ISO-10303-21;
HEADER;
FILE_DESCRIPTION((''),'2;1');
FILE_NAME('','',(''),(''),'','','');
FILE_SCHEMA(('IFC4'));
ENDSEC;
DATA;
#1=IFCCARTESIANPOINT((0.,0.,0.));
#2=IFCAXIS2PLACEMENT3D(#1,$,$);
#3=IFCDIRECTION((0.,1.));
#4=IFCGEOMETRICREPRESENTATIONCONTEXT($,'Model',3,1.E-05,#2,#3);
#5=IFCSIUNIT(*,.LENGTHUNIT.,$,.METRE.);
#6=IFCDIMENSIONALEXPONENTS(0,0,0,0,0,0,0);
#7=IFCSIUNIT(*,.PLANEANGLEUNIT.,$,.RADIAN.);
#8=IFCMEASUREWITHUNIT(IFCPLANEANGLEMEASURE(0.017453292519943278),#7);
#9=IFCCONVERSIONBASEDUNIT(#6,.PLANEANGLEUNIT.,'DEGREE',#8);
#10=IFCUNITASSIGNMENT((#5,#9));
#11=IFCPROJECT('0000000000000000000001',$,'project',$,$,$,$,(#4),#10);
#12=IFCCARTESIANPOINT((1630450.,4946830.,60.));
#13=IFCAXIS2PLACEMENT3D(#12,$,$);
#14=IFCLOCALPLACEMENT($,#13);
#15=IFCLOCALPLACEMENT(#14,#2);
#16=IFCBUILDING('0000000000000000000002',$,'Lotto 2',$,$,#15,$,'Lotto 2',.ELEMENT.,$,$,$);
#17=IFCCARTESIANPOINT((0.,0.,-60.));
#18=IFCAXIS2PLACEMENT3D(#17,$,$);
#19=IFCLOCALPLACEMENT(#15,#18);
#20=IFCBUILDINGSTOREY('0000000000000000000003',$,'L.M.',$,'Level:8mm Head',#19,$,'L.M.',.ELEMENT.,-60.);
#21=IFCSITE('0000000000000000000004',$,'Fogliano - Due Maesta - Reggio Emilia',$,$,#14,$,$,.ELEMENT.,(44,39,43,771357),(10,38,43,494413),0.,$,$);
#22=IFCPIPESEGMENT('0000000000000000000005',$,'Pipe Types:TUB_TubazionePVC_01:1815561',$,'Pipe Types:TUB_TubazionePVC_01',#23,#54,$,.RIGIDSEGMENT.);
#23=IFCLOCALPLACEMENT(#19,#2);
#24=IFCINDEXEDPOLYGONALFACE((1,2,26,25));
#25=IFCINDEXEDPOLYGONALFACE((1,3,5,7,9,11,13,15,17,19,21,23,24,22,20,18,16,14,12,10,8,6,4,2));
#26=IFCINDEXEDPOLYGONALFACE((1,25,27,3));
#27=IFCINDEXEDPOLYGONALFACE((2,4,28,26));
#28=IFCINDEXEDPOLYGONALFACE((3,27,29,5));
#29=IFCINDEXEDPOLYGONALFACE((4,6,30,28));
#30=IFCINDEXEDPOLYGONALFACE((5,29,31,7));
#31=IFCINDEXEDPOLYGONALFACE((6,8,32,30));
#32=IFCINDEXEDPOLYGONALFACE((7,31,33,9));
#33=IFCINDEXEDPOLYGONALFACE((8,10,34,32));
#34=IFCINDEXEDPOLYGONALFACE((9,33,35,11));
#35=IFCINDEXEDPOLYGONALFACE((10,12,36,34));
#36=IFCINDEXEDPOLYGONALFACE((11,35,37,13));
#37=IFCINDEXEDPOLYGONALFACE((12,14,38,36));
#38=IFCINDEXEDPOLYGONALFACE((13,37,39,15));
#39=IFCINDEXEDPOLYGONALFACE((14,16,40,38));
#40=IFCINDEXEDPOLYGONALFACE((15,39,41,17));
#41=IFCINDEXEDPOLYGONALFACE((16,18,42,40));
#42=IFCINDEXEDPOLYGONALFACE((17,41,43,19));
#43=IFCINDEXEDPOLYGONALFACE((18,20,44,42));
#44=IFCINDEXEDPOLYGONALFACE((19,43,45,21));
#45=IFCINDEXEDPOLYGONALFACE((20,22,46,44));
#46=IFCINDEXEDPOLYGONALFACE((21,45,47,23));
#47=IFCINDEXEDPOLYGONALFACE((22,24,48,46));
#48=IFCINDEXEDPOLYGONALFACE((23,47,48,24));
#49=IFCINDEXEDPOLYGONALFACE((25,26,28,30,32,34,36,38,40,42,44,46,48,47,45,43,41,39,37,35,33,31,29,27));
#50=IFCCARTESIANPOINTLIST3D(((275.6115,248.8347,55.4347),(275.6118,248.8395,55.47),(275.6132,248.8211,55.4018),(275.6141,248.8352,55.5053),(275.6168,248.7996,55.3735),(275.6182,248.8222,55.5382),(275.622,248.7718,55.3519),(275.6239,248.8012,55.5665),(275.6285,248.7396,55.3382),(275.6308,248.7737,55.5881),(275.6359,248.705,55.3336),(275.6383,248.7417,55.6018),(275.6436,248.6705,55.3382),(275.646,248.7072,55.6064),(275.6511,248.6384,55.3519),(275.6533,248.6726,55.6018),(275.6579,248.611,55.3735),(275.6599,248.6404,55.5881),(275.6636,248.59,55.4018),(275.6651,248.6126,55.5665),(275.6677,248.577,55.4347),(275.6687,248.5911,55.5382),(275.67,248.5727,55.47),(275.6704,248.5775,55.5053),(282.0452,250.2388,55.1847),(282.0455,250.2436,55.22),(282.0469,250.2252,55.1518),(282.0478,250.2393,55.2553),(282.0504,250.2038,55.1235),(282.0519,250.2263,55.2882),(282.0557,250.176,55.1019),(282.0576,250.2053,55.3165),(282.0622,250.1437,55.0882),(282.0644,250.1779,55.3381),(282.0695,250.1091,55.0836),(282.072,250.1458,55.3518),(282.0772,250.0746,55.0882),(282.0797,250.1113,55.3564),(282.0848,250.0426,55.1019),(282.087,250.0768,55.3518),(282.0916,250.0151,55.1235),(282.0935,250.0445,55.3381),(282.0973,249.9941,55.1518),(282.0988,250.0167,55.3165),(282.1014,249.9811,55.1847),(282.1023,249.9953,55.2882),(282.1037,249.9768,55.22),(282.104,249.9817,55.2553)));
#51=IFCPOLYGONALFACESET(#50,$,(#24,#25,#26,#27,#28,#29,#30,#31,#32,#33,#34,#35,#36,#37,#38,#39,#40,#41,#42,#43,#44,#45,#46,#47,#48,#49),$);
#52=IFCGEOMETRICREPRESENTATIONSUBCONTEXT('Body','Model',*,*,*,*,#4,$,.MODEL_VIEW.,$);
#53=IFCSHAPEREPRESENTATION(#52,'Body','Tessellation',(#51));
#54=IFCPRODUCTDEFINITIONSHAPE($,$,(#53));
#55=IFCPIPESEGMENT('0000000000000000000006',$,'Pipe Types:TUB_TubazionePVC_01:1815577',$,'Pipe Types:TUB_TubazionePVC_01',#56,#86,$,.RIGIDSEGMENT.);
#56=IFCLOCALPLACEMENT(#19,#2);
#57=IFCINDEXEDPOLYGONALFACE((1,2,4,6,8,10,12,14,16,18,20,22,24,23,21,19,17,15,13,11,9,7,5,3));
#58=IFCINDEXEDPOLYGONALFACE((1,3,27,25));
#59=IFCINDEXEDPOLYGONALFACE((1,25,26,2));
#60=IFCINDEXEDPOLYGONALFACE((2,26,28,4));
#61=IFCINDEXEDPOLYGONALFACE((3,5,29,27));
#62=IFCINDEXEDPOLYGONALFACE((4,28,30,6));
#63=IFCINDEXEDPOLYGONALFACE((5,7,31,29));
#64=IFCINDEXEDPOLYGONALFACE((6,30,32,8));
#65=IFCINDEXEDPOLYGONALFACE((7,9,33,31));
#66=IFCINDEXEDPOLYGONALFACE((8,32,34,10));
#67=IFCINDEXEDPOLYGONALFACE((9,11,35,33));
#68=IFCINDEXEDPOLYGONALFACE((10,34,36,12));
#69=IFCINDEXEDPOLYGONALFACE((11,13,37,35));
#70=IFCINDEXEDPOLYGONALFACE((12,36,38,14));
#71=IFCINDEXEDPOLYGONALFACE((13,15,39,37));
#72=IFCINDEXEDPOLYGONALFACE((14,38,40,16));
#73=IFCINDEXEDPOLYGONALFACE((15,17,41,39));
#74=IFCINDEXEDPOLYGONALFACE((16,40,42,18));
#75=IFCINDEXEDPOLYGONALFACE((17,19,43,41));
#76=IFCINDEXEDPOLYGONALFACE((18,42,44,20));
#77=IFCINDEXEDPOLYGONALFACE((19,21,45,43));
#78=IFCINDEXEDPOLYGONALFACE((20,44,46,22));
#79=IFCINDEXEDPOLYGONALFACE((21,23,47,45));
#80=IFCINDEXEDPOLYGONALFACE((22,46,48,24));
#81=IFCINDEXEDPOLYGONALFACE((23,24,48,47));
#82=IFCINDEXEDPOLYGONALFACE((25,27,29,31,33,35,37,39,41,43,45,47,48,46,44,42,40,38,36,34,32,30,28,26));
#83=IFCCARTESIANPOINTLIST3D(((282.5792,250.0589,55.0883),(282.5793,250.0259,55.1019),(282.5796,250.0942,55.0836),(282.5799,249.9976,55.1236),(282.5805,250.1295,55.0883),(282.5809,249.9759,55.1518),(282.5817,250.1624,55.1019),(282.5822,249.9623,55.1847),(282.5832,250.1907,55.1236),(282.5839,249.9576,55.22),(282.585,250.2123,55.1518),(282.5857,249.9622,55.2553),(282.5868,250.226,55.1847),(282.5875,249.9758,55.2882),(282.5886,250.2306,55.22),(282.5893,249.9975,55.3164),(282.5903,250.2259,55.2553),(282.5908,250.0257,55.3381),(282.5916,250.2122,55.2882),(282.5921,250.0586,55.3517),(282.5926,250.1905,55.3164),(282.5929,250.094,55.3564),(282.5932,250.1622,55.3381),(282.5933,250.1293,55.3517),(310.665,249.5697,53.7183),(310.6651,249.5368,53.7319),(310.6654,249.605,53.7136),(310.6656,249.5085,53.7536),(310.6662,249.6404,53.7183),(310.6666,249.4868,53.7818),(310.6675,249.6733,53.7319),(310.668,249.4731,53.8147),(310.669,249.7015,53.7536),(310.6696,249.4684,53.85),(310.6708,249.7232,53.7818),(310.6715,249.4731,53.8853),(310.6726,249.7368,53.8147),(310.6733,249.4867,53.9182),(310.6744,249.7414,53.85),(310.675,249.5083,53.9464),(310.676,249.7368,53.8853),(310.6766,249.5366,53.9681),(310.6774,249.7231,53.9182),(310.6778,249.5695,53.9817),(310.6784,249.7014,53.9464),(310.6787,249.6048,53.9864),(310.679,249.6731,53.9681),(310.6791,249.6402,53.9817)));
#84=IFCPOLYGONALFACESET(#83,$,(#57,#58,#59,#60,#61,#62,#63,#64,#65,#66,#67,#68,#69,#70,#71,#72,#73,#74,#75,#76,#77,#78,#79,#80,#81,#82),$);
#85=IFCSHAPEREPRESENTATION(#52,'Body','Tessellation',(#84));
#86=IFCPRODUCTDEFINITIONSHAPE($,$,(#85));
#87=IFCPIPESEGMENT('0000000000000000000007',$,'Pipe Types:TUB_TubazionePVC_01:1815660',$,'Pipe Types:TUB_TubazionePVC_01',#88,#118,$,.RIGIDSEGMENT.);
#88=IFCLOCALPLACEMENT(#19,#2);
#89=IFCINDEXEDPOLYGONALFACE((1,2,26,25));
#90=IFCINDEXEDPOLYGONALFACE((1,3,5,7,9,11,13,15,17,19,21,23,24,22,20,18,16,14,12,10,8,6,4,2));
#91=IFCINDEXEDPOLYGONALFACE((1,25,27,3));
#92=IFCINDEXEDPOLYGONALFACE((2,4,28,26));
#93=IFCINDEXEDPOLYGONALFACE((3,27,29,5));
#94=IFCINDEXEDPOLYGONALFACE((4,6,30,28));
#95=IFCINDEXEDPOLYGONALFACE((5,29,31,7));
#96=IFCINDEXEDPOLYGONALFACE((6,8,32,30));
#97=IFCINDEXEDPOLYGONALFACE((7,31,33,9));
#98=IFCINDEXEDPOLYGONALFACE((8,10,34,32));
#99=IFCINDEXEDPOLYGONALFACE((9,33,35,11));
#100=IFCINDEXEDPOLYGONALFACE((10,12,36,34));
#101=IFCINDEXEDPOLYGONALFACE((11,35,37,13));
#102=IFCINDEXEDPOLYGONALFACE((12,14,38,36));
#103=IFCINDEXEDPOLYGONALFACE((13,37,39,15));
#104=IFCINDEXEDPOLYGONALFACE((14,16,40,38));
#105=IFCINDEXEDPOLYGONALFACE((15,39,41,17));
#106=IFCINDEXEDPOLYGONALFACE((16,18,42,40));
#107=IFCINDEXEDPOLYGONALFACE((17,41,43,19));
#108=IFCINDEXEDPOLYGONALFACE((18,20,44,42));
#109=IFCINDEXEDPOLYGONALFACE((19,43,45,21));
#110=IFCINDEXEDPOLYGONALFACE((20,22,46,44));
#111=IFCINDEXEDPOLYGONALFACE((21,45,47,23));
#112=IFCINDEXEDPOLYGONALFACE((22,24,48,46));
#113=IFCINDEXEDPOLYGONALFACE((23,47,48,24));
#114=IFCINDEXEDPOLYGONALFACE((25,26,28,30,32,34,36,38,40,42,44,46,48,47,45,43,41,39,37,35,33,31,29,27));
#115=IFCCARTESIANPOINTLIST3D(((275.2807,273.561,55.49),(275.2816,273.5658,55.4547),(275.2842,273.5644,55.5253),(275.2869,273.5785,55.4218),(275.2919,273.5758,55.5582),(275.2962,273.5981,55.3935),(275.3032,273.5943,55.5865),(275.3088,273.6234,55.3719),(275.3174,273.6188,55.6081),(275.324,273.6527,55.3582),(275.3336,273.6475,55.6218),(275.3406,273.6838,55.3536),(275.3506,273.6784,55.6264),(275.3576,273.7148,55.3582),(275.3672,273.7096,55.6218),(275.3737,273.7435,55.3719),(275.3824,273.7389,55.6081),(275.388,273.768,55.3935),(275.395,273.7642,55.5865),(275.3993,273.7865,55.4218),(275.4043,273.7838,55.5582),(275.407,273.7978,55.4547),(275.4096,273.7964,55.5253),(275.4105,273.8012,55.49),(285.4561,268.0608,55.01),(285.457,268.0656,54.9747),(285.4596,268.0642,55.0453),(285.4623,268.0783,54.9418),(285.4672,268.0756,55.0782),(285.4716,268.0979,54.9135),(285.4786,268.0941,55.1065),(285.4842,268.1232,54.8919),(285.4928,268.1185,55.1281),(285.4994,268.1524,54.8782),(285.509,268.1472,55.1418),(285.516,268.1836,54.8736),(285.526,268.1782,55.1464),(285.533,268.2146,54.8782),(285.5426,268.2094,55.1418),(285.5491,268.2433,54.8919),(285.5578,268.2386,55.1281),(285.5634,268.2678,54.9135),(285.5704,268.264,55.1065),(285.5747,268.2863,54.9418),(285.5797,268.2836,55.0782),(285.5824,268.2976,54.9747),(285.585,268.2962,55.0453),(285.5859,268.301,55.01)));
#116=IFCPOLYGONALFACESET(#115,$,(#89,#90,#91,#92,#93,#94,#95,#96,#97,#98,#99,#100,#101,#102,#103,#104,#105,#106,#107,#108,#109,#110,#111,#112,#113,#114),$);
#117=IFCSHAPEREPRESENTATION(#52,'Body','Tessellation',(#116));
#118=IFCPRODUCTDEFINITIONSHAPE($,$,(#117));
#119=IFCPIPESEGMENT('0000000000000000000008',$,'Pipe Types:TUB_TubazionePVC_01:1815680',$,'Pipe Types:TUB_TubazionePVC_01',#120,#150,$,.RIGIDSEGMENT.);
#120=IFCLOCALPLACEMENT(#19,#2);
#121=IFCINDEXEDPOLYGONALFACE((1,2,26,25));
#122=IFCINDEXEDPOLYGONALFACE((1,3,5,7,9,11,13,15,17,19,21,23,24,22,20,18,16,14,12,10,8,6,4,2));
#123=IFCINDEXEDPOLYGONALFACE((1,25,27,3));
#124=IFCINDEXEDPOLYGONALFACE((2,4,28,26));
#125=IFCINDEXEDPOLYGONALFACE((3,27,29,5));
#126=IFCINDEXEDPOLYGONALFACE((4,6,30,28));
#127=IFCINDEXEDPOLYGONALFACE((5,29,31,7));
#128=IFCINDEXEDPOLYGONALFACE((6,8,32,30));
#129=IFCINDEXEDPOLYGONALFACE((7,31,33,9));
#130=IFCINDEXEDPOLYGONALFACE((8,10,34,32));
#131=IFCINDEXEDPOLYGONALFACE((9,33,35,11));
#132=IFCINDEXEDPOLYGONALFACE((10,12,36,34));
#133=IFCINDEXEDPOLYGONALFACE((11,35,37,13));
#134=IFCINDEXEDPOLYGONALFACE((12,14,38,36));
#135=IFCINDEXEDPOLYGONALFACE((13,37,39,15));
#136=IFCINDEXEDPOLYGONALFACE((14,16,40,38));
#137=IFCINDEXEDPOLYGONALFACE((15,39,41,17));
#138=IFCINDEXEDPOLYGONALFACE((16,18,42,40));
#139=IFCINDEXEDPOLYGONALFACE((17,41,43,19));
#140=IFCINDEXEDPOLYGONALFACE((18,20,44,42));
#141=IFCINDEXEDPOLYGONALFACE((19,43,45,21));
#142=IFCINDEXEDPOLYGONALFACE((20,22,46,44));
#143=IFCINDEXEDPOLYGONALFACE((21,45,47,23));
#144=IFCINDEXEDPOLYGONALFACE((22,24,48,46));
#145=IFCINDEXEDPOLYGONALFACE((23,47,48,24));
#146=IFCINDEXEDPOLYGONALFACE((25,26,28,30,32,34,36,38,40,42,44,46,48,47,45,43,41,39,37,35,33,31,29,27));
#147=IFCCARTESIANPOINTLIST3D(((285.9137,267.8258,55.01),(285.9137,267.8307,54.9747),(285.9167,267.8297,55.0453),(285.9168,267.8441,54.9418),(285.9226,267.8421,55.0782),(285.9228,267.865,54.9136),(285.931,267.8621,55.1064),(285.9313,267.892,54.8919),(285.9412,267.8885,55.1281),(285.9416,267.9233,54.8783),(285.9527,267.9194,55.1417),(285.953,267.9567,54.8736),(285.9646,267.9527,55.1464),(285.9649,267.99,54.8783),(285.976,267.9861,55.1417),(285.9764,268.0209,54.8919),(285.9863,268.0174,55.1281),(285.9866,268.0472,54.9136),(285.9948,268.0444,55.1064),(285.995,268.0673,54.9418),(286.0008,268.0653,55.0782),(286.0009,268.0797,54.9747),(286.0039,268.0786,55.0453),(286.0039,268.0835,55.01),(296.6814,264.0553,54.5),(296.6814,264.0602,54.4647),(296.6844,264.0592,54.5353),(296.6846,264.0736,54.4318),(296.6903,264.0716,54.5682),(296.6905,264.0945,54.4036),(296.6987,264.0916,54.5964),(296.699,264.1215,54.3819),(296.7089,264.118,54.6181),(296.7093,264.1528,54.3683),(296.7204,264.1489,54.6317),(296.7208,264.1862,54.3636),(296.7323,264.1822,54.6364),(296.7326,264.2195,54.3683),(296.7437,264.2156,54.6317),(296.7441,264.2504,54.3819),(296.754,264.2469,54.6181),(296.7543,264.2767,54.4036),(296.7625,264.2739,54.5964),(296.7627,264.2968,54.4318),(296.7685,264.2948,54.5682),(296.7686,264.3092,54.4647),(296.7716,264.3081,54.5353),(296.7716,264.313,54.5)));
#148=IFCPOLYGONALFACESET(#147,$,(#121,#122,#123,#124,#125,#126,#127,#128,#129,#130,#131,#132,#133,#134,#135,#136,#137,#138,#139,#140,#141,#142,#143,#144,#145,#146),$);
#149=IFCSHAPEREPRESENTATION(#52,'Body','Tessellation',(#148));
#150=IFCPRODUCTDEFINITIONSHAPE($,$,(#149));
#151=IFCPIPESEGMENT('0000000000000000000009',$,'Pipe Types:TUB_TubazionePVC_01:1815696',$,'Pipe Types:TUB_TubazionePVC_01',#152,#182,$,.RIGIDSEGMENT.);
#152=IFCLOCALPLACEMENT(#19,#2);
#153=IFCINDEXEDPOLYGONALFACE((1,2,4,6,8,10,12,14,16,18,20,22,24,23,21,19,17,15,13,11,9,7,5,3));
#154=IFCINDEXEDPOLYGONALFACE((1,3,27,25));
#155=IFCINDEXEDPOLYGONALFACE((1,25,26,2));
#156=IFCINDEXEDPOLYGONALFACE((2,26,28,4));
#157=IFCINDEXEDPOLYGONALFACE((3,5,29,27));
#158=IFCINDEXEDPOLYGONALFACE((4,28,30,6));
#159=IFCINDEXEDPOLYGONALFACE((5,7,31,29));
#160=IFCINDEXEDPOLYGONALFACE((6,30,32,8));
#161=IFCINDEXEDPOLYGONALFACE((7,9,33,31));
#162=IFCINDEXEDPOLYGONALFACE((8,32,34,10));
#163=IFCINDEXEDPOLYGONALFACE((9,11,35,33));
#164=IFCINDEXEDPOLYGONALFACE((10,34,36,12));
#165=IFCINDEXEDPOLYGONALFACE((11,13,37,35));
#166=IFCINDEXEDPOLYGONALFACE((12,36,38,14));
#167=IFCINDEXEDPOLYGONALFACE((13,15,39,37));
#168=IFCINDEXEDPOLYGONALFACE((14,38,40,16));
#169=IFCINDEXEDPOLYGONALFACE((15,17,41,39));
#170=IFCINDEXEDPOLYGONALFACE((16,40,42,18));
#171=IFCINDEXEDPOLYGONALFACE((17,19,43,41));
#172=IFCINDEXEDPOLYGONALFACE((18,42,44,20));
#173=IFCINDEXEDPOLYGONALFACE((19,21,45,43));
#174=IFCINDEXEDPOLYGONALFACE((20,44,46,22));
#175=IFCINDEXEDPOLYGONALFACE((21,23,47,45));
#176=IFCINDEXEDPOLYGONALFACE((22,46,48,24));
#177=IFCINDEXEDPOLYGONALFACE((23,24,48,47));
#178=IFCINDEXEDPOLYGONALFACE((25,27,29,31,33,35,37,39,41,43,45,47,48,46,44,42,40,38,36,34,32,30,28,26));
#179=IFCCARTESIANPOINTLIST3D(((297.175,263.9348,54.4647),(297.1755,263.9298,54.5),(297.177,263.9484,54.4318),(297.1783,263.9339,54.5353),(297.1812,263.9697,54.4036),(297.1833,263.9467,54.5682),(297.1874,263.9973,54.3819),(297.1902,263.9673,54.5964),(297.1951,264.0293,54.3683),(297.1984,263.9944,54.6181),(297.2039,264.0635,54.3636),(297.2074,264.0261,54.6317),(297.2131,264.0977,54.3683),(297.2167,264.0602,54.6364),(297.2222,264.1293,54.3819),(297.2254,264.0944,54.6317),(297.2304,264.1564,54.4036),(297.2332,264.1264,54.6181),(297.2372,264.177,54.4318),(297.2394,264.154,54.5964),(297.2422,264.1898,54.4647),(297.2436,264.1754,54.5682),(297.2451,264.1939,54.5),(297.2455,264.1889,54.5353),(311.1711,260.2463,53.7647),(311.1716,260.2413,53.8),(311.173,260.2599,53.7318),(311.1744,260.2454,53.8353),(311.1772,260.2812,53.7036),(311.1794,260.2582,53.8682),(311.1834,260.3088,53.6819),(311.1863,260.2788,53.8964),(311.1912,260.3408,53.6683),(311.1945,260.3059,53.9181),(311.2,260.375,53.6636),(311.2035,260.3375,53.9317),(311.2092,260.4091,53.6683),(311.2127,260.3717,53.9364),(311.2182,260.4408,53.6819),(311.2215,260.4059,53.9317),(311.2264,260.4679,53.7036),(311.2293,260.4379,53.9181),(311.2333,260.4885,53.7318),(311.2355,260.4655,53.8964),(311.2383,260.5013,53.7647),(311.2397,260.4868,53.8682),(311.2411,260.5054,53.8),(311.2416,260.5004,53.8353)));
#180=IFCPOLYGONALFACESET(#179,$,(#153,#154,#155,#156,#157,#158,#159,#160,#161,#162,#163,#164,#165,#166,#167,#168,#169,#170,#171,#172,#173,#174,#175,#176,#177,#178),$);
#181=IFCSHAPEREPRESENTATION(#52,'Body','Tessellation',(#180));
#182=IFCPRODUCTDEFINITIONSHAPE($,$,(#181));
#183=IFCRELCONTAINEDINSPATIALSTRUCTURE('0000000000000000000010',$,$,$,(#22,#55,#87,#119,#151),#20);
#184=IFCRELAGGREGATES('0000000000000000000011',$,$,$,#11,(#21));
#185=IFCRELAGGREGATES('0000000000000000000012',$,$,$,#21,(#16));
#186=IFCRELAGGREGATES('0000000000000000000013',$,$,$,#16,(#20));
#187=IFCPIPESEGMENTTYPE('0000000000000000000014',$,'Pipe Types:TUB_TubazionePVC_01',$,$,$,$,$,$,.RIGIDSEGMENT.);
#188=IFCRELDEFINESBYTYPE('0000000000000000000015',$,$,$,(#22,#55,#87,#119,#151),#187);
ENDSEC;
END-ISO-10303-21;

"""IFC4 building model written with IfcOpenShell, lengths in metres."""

from ifc_helpers import new_model, entity, si_unit, converted_unit, direction, frame, origin, place, context, subcontext, project, spatial, arc, indexed_curve, outline, extrude, type_object, element, save


model = new_model("IFC4")

# Units and contexts
model_context = context("Model", 3, precision=1e-05, world=origin(), true_north=direction((0.0, 1.0)))
body_context = subcontext(model_context, "Body", "Model", "MODEL_VIEW")
ifc_project = project(units=[si_unit("LENGTHUNIT", "METRE"), converted_unit("PLANEANGLEUNIT", "DEGREE", entity("IfcPlaneAngleMeasure", 0.017453292519943278), si_unit("PLANEANGLEUNIT", "RADIAN"), dimensions=[0, 0, 0, 0, 0, 0, 0])], contexts=[model_context])

# Site, building, storey
site_placement = place(None, frame((1630450.0, 4946830.0, 60.0)))
site = spatial("IfcSite", under=ifc_project, at=site_placement, Name="Fogliano - Due Maesta - Reggio Emilia", CompositionType="ELEMENT", RefLatitude=(44, 39, 43, 771357), RefLongitude=(10, 38, 43, 494413), RefElevation=0.0)
building_placement = place(site_placement, origin())
building = spatial("IfcBuilding", under=site, at=building_placement, Name="Lotto 2", LongName="Lotto 2", CompositionType="ELEMENT")
storey_placement = place(building_placement, frame((0.0, 0.0, -60.0)))
storey = spatial("IfcBuildingStorey", under=building, at=storey_placement, Name="L.M.", ObjectType="Level:8mm Head", LongName="L.M.", CompositionType="ELEMENT", Elevation=-60.0)

# Pipe segments
pipe_segment_type = type_object("IfcPipeSegmentType", Name="Pipe Types:TUB_TubazionePVC_01", PredefinedType="RIGIDSEGMENT")
pipe_segment_1_placement = place(storey_placement, origin())
element("IfcPipeSegment", 1, at=pipe_segment_1_placement, inside=storey, type_object=pipe_segment_type, Name="Pipe Types:TUB_TubazionePVC_01:1815561", ObjectType="Pipe Types:TUB_TubazionePVC_01", PredefinedType="RIGIDSEGMENT", context=body_context, shape_type="SweptSolid", body=[
    extrude(outline(indexed_curve([(0.1365, 0.0), (0.0965, 0.0965), (0.0, 0.1365), (-0.0965, 0.0965), (-0.1365, 0.0), (-0.0965, -0.0965), (0.0, -0.1365), (0.0965, -0.0965)], segments=[arc(1, 2, 3), arc(3, 4, 5), arc(5, 6, 7), arc(7, 8, 1)], self_intersect=False)), frame((275.6409, 248.7061, 55.47), z_axis=(0.9763, 0.213072, -0.037937), x_axis=(0.213226, -0.977003, 0.0)), (0.0, 0.0, 1.0), 6.5899),
])
pipe_segment_2_placement = place(storey_placement, origin())
element("IfcPipeSegment", 2, at=pipe_segment_2_placement, inside=storey, type_object=pipe_segment_type, Name="Pipe Types:TUB_TubazionePVC_01:1815577", ObjectType="Pipe Types:TUB_TubazionePVC_01", PredefinedType="RIGIDSEGMENT", context=body_context, shape_type="SweptSolid", body=[
    extrude(outline(indexed_curve([(0.1365, 0.0), (0.0965, 0.0965), (0.0, 0.1365), (-0.0965, 0.0965), (-0.1365, 0.0), (-0.0965, -0.0965), (0.0, -0.1365), (0.0965, -0.0965)], segments=[arc(1, 2, 3), arc(3, 4, 5), arc(5, 6, 7), arc(7, 8, 1)], self_intersect=False)), frame((310.672, 249.6049, 53.85), z_axis=(-0.998661, 0.017393, 0.048714), x_axis=(-0.017413, -0.999848, 0.0)), (0.0, 0.0, 1.0), 28.1234),
])
pipe_segment_3_placement = place(storey_placement, origin())
element("IfcPipeSegment", 3, at=pipe_segment_3_placement, inside=storey, type_object=pipe_segment_type, Name="Pipe Types:TUB_TubazionePVC_01:1815660", ObjectType="Pipe Types:TUB_TubazionePVC_01", PredefinedType="RIGIDSEGMENT", context=body_context, shape_type="SweptSolid", body=[
    extrude(outline(indexed_curve([(0.1365, 0.0), (0.0965, 0.0965), (0.0, 0.1365), (-0.0965, 0.0965), (-0.1365, 0.0), (-0.0965, -0.0965), (0.0, -0.1365), (0.0965, -0.0965)], segments=[arc(1, 2, 3), arc(3, 4, 5), arc(5, 6, 7), arc(7, 8, 1)], self_intersect=False)), frame((285.521, 268.1809, 55.01), z_axis=(-0.87895, 0.475108, 0.041462), x_axis=(-0.475516, -0.879707, 0.0)), (0.0, 0.0, 1.0), 11.5768),
])
pipe_segment_4_placement = place(storey_placement, origin())
element("IfcPipeSegment", 4, at=pipe_segment_4_placement, inside=storey, type_object=pipe_segment_type, Name="Pipe Types:TUB_TubazionePVC_01:1815680", ObjectType="Pipe Types:TUB_TubazionePVC_01", PredefinedType="RIGIDSEGMENT", context=body_context, shape_type="SweptSolid", body=[
    extrude(outline(indexed_curve([(0.1365, 0.0), (0.0965, 0.0965), (0.0, 0.1365), (-0.0965, 0.0965), (-0.1365, 0.0), (-0.0965, -0.0965), (0.0, -0.1365), (0.0965, -0.0965)], segments=[arc(1, 2, 3), arc(3, 4, 5), arc(5, 6, 7), arc(7, 8, 1)], self_intersect=False)), frame((296.7265, 264.1842, 54.5), z_axis=(-0.942867, 0.330161, 0.044658), x_axis=(-0.330491, -0.943809, 0.0)), (0.0, 0.0, 1.0), 11.4202),
])
pipe_segment_5_placement = place(storey_placement, origin())
element("IfcPipeSegment", 5, at=pipe_segment_5_placement, inside=storey, type_object=pipe_segment_type, Name="Pipe Types:TUB_TubazionePVC_01:1815696", ObjectType="Pipe Types:TUB_TubazionePVC_01", PredefinedType="RIGIDSEGMENT", context=body_context, shape_type="SweptSolid", body=[
    extrude(outline(indexed_curve([(0.1365, 0.0), (0.0965, 0.0965), (0.0, 0.1365), (-0.0965, 0.0965), (-0.1365, 0.0), (-0.0965, -0.0965), (0.0, -0.1365), (0.0965, -0.0965)], segments=[arc(1, 2, 3), arc(3, 4, 5), arc(5, 6, 7), arc(7, 8, 1)], self_intersect=False)), frame((311.2063, 260.3733, 53.8), z_axis=(-0.965855, 0.254541, 0.048306), x_axis=(-0.254839, -0.966984, 0.0)), (0.0, 0.0, 1.0), 14.4909),
])

save(model, "model.ifc")
